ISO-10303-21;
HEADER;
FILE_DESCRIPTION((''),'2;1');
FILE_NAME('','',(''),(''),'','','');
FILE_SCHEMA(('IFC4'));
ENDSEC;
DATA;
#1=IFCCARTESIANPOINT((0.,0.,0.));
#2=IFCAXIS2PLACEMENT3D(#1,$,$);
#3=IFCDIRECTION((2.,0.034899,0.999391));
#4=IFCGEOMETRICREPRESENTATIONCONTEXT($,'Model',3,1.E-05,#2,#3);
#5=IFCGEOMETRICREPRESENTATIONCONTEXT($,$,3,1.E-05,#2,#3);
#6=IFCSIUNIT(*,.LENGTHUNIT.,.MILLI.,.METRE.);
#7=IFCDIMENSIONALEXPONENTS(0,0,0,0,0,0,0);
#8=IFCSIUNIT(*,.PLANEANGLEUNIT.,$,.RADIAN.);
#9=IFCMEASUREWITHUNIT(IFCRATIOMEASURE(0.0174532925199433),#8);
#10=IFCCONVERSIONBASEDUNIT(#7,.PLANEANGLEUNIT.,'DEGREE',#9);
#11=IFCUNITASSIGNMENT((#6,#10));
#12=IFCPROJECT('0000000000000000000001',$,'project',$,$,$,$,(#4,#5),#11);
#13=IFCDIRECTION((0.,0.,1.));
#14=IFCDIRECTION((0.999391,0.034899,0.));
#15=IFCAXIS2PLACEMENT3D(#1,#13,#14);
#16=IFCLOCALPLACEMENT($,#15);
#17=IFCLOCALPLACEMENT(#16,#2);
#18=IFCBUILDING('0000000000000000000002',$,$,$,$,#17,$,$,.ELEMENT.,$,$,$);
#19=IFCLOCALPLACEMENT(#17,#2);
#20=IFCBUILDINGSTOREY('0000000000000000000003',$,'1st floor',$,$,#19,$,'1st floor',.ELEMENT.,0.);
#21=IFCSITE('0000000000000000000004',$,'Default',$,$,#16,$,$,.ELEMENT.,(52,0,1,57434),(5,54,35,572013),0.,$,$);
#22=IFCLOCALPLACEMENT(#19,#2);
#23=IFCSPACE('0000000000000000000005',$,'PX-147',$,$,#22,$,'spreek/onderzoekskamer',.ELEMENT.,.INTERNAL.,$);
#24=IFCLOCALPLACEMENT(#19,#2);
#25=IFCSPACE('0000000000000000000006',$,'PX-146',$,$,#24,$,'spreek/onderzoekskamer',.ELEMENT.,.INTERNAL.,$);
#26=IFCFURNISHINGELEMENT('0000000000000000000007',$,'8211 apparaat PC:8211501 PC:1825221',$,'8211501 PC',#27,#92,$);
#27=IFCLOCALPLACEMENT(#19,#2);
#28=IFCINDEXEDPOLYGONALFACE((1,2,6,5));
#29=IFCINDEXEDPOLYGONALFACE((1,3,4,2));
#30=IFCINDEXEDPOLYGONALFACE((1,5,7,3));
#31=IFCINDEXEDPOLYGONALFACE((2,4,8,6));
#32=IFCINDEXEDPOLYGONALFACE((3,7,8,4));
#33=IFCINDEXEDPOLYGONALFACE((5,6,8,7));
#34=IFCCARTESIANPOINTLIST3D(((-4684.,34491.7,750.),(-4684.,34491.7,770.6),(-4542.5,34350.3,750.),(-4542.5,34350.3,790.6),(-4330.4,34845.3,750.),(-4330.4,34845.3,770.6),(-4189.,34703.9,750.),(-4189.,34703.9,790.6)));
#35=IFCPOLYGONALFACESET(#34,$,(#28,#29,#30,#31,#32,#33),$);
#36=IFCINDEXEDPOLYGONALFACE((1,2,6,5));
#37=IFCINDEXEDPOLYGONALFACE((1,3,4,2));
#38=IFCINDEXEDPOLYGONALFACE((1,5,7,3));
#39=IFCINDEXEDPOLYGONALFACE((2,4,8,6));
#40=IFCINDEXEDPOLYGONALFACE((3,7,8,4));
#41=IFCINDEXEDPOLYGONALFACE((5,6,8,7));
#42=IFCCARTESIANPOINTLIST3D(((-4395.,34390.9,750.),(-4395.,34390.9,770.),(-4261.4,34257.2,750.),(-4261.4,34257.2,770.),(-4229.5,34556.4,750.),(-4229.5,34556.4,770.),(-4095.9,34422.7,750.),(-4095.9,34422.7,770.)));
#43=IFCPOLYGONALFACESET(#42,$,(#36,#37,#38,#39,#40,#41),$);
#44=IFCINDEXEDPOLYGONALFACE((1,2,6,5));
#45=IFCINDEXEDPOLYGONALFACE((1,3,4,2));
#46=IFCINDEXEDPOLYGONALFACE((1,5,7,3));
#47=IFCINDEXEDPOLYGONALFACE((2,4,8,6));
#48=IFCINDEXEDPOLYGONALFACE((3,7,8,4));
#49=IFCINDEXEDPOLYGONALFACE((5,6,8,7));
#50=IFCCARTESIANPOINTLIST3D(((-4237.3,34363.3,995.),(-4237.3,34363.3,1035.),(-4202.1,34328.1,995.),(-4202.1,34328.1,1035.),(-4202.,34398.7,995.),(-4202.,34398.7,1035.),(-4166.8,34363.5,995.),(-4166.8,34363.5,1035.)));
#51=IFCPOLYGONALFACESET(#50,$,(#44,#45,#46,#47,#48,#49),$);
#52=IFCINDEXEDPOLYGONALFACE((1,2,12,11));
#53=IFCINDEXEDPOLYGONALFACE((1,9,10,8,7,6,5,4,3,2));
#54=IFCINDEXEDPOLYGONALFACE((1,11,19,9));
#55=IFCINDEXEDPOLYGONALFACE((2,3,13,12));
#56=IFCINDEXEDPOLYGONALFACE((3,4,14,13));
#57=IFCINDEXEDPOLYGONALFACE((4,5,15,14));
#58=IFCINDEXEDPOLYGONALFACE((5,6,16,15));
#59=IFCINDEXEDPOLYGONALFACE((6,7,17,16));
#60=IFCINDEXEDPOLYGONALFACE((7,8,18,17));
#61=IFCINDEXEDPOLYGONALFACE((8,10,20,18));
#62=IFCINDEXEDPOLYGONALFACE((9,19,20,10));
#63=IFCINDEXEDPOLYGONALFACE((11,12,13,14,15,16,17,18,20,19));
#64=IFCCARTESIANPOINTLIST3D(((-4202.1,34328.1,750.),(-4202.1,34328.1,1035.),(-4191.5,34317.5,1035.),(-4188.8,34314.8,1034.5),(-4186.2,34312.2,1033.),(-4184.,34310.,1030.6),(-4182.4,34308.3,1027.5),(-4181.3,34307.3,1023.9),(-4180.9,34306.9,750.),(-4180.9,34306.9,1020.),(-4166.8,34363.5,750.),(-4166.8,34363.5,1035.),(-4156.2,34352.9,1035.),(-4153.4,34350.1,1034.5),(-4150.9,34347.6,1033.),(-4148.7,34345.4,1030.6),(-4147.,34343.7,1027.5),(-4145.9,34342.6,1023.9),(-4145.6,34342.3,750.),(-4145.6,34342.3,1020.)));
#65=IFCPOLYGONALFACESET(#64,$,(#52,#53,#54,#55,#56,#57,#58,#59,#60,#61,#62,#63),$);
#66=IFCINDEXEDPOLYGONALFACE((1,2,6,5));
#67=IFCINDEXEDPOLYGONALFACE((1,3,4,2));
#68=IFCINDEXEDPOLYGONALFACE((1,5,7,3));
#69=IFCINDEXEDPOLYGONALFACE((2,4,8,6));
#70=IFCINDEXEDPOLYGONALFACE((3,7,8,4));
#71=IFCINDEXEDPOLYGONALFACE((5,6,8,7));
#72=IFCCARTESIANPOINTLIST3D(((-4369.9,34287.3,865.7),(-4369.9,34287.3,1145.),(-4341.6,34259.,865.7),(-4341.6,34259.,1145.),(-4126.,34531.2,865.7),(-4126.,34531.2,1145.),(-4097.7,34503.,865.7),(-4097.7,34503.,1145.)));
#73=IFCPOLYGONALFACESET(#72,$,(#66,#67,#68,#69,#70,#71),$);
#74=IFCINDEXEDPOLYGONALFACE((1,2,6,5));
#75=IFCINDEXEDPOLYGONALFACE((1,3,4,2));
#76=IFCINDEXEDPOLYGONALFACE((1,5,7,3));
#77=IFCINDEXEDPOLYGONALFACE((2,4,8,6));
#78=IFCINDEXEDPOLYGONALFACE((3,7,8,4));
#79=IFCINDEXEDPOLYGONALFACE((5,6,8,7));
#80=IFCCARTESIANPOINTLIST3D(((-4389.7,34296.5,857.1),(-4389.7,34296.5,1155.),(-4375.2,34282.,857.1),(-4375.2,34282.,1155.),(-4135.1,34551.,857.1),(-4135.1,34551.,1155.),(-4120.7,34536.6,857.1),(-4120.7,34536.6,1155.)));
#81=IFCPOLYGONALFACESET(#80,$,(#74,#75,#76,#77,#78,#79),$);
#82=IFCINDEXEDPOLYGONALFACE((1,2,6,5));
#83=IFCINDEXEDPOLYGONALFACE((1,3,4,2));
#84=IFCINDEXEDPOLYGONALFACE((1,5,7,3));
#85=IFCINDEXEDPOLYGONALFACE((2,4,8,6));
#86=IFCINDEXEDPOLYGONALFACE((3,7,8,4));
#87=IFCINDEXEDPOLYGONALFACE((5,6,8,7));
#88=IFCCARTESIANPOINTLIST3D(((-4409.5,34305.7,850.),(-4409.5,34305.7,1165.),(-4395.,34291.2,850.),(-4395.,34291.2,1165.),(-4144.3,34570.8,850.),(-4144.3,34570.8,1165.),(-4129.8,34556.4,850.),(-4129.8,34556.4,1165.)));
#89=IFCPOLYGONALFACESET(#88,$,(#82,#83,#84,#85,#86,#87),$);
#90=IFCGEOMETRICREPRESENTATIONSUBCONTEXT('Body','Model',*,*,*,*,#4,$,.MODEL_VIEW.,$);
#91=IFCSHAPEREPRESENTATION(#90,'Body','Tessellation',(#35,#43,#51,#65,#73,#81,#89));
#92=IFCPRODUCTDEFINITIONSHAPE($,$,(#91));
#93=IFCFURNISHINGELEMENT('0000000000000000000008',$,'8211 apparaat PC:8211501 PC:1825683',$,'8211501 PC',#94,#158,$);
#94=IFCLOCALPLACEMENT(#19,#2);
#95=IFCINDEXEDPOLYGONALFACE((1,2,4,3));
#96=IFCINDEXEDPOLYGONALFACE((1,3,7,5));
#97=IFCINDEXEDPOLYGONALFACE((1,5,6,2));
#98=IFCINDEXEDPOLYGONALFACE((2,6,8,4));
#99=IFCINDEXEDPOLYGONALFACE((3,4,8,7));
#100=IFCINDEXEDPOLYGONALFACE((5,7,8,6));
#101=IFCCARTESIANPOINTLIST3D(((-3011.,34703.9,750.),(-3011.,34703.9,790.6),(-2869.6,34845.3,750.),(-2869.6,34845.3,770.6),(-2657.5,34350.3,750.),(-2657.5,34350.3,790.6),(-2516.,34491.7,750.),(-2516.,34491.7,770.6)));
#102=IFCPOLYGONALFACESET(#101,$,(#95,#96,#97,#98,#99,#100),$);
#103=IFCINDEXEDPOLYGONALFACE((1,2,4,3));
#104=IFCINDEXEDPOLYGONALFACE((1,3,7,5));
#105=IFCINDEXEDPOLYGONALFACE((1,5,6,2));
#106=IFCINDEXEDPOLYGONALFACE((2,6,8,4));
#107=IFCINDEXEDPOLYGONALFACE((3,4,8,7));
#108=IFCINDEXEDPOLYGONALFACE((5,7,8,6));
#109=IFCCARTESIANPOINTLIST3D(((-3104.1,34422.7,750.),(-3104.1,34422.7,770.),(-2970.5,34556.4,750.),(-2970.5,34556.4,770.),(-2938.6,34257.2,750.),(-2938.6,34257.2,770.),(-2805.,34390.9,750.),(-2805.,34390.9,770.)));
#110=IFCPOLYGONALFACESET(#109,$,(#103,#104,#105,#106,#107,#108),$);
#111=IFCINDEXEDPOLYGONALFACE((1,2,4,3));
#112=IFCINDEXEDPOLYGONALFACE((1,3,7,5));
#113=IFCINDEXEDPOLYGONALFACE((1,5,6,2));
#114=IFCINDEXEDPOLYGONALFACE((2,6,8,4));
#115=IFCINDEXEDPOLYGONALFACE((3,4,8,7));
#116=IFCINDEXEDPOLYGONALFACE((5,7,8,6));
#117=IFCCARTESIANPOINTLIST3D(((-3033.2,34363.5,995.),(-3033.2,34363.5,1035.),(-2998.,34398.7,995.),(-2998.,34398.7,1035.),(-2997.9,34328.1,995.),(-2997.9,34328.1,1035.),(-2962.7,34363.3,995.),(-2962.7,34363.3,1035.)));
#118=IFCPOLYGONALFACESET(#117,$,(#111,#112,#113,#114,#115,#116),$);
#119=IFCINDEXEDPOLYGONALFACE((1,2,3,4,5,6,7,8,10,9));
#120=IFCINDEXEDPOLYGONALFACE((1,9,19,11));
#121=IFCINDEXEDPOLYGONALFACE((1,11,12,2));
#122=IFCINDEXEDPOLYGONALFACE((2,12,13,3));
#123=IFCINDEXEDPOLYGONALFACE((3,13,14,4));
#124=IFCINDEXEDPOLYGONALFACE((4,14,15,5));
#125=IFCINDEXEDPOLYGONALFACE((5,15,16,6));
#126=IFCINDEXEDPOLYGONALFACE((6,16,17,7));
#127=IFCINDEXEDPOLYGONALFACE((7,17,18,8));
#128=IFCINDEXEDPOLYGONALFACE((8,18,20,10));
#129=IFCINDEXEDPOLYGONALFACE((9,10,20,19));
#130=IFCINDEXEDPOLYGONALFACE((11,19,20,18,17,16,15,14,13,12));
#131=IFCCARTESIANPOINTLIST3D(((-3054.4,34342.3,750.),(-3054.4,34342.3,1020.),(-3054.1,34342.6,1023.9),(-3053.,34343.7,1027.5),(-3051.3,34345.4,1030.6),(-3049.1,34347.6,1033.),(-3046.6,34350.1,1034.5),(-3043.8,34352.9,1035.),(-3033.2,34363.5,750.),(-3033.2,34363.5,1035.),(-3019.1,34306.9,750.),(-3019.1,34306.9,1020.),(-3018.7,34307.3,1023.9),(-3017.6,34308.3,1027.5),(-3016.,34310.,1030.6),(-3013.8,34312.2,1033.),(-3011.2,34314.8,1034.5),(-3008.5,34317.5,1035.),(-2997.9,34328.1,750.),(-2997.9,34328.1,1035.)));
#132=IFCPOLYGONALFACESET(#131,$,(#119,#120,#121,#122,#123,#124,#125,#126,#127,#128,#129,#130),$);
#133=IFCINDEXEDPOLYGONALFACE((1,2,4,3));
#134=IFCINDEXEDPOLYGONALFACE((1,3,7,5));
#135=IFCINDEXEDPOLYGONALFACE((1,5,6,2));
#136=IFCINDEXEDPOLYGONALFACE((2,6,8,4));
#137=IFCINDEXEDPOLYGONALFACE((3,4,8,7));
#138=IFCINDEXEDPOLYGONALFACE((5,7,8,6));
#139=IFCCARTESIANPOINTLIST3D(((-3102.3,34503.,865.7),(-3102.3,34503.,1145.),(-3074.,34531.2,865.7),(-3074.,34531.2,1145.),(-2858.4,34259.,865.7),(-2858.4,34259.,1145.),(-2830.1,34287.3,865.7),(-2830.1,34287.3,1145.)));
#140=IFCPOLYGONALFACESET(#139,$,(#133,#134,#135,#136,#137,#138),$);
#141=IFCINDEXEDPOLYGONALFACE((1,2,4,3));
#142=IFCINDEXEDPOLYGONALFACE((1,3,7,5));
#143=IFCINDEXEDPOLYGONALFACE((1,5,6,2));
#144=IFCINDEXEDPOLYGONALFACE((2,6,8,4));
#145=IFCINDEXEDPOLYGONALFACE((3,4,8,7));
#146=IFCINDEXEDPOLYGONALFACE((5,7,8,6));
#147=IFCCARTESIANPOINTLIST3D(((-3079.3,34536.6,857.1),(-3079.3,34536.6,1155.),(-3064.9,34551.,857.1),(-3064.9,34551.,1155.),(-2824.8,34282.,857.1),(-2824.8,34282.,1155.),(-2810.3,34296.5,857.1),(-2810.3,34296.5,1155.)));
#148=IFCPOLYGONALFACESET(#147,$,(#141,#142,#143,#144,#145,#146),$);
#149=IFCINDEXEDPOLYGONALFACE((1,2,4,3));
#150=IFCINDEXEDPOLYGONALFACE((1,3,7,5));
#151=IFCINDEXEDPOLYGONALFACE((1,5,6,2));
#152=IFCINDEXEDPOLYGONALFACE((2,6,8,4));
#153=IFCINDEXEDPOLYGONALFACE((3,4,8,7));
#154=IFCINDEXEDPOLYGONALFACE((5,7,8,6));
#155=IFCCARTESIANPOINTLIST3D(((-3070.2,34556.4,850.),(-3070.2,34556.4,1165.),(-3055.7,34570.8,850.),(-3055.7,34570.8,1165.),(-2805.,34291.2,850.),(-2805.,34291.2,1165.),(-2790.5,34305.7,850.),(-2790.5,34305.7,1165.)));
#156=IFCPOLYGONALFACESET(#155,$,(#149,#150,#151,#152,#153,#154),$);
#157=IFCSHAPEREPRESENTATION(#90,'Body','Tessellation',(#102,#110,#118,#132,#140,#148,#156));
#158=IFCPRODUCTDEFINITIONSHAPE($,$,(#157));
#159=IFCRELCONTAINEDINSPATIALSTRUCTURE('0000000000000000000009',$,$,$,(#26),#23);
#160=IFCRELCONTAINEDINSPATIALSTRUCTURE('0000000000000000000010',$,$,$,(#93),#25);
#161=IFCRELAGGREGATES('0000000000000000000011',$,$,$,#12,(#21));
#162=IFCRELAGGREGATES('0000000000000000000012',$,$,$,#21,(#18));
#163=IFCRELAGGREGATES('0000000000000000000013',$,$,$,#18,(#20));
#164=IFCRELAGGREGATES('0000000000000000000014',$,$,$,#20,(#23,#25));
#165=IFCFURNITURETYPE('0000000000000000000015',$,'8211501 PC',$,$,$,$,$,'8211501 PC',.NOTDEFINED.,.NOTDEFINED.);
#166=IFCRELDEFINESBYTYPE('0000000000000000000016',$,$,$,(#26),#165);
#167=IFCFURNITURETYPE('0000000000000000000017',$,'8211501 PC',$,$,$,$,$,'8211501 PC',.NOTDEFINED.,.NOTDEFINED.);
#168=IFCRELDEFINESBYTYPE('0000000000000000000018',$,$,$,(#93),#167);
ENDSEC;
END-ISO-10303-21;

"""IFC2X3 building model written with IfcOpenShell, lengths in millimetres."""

from ifc_helpers import new_model, entity, si_unit, converted_unit, direction, frame, frame_2d, origin, origin_2d_with_axis, place, context, subcontext, project, spatial, polyline, circle_curve, parameter, trimmed, segment, composite_curve, rectangle, outline, extrude, source, transform, mapped, type_object, type_shapes, element, save


model = new_model("IFC2X3")

# Units and contexts
model_context = context("Model", 3, precision=1e-05, world=origin(), true_north=direction((2.0, 0.034899, 0.999391)))
context_of_model = context(None, 3, precision=1e-05, world=origin(), true_north=direction((2.0, 0.034899, 0.999391)))
body_context = subcontext(model_context, "Body", "Model", "MODEL_VIEW")
ifc_project = project(units=[si_unit("LENGTHUNIT", "METRE", prefix="MILLI"), converted_unit("PLANEANGLEUNIT", "DEGREE", entity("IfcRatioMeasure", 0.0174532925199433), si_unit("PLANEANGLEUNIT", "RADIAN"), dimensions=[0, 0, 0, 0, 0, 0, 0])], contexts=[model_context, context_of_model])

# Site, building, storey
site_placement = place(None, frame((0.0, 0.0, 0.0), z_axis=(0.0, 0.0, 1.0), x_axis=(0.999391, 0.034899, 0.0)))
site = spatial("IfcSite", under=ifc_project, at=site_placement, Name="Default", CompositionType="ELEMENT", RefLatitude=(52, 0, 1, 57434), RefLongitude=(5, 54, 35, 572013), RefElevation=0.0)
building_placement = place(site_placement, origin())
building = spatial("IfcBuilding", under=site, at=building_placement, CompositionType="ELEMENT")
storey_placement = place(building_placement, origin())
storey = spatial("IfcBuildingStorey", under=building, at=storey_placement, Name="1st floor", LongName="1st floor", CompositionType="ELEMENT", Elevation=0.0)

# Shared definitions
space_1_placement = place(storey_placement, origin())
space_1 = spatial("IfcSpace", under=storey, at=space_1_placement, Name="PX-147", LongName="spreek/onderzoekskamer", CompositionType="ELEMENT", InteriorOrExteriorSpace="INTERNAL")

# Furnishing element
furniture_type_1 = type_object("IfcFurnitureType", Name="8211501 PC", ElementType="8211501 PC", AssemblyPlace="NOTDEFINED")
shared_shape_1 = source(origin(), body_context, "Body", "SweptSolid", [
    extrude(outline(polyline([(-5.3, -100.0), (15.3, -100.0), (15.3, 100.0), (-25.3, 100.0), (-5.3, -100.0)])), frame((-205.3, -510.0, 765.3), z_axis=(1.0, 0.0, 0.0), x_axis=(0.0, 0.0, -1.0)), (0.0, 0.0, 1.0), 500.0),
    extrude(rectangle(XDim=189.0, YDim=234.0, at=origin_2d_with_axis()), frame((44.7, -239.9, 750.0), z_axis=(0.0, 0.0, 1.0), x_axis=(0.0, 1.0, 0.0)), (0.0, 0.0, 1.0), 20.0),
    extrude(rectangle(XDim=49.8, YDim=50.0, at=frame_2d((0.0, 0.0), x_axis=(1.0, 0.0))), frame((44.7, -178.5, 995.0), z_axis=(0.0, 0.0, 1.0), x_axis=(0.0, 1.0, 0.0)), (0.0, 0.0, 1.0), 40.0),
    extrude(outline(composite_curve([segment(polyline([(-117.0, -15.0), (168.0, -15.0)]), True, "CONTINUOUS"), segment(polyline([(168.0, -15.0), (168.0, 15.0)]), True, "CONTINUOUS"), segment(polyline([(168.0, 15.0), (-102.0, 15.0)]), True, "CONTINUOUS"), segment(trimmed(circle_curve(frame_2d((-102.0, 0.0), x_axis=(0.0, 1.0)), 15.0), [parameter(360.0)], [parameter(90.0)], True, "PARAMETER"), True, "CONTINUOUS"), segment(polyline([(-117.0, 0.0), (-117.0, -15.0)]), True, "CONTINUOUS")], self_intersect=False)), frame((19.7, -138.6, 918.0), z_axis=(1.0, 0.0, 0.0), x_axis=(0.0, 0.0, -1.0)), (0.0, 0.0, 1.0), 50.0),
    extrude(rectangle(XDim=40.0, YDim=345.0, at=origin_2d_with_axis()), frame((44.7, -223.4, 865.7), z_axis=(0.0, 0.0, 1.0), x_axis=(0.0, 1.0, 0.0)), (0.0, 0.0, 1.0), 279.3),
    extrude(rectangle(XDim=20.5, YDim=360.0, at=origin_2d_with_axis()), frame((44.7, -253.6, 857.1), z_axis=(0.0, 0.0, 1.0), x_axis=(0.0, 1.0, 0.0)), (0.0, 0.0, 1.0), 297.9),
    extrude(rectangle(XDim=20.5, YDim=375.0, at=origin_2d_with_axis()), frame((44.7, -274.1, 850.0), z_axis=(0.0, 0.0, 1.0), x_axis=(0.0, 1.0, 0.0)), (0.0, 0.0, 1.0), 315.0),
])
type_shapes(furniture_type_1, [shared_shape_1])
furnishing_1_placement = place(space_1_placement, frame((-4044.2, 34268.8, 0.0), z_axis=(0.0, 0.0, 1.0), x_axis=(-0.707107, -0.707107, 0.0)))
element("IfcFurnishingElement", 1, at=furnishing_1_placement, inside=space_1, type_object=furniture_type_1, Name="8211 apparaat PC:8211501 PC:1825221", ObjectType="8211501 PC", context=body_context, shape_type="MappedRepresentation", body=[
    mapped(shared_shape_1, transform((0.0, 0.0, 0.0), scale=1.0)),
])

# Shared definitions
space_2_placement = place(storey_placement, origin())
space_2 = spatial("IfcSpace", under=storey, at=space_2_placement, Name="PX-146", LongName="spreek/onderzoekskamer", CompositionType="ELEMENT", InteriorOrExteriorSpace="INTERNAL")

# Furnishing element
furniture_type_2 = type_object("IfcFurnitureType", Name="8211501 PC", ElementType="8211501 PC", AssemblyPlace="NOTDEFINED")
shared_shape_2 = source(origin(), body_context, "Body", "SweptSolid", [
    extrude(outline(polyline([(-99.0, -15.2), (102.0, -15.2), (98.0, 25.2), (-101.0, 5.3), (-99.0, -15.2)])), frame((-205.3, 510.0, 765.3), z_axis=(1.0, 0.0, 0.0), x_axis=(0.0, -0.995037, 0.099504)), (0.0, 0.0, 1.0), 500.0),
    extrude(rectangle(XDim=234.0, YDim=189.0, at=frame_2d((0.0, 0.0), x_axis=(1.0, 0.0))), frame((44.7, 239.9, 750.0), z_axis=(0.0, 0.0, 1.0), x_axis=(-1.0, 0.0, 0.0)), (0.0, 0.0, 1.0), 20.0),
    extrude(rectangle(XDim=50.0, YDim=49.8, at=frame_2d((0.0, 0.0), x_axis=(1.0, 0.0))), frame((44.7, 178.5, 995.0), z_axis=(0.0, 0.0, 1.0), x_axis=(-1.0, 0.0, 0.0)), (0.0, 0.0, 1.0), 40.0),
    extrude(outline(composite_curve([segment(polyline([(-15.0, -117.0), (0.0, -117.0)]), True, "CONTINUOUS"), segment(trimmed(circle_curve(frame_2d((0.0, -102.0), x_axis=(1.0, 0.0)), 15.0), [parameter(270.0)], [parameter(0.0)], True, "PARAMETER"), True, "CONTINUOUS"), segment(polyline([(15.0, -102.0), (15.0, 168.0)]), True, "CONTINUOUS"), segment(polyline([(15.0, 168.0), (-15.0, 168.0)]), True, "CONTINUOUS"), segment(polyline([(-15.0, 168.0), (-15.0, -117.0)]), True, "CONTINUOUS")], self_intersect=False)), frame((19.7, 138.6, 918.0), z_axis=(1.0, 0.0, 0.0), x_axis=(0.0, -1.0, 0.0)), (0.0, 0.0, 1.0), 50.0),
    extrude(rectangle(XDim=345.0, YDim=40.0, at=origin_2d_with_axis()), frame((44.7, 223.4, 865.7), z_axis=(0.0, 0.0, 1.0), x_axis=(-1.0, 0.0, 0.0)), (0.0, 0.0, 1.0), 279.3),
    extrude(rectangle(XDim=360.0, YDim=20.5, at=origin_2d_with_axis()), frame((44.7, 253.6, 857.1), z_axis=(0.0, 0.0, 1.0), x_axis=(-1.0, 0.0, 0.0)), (0.0, 0.0, 1.0), 297.9),
    extrude(rectangle(XDim=375.0, YDim=20.5, at=origin_2d_with_axis()), frame((44.7, 274.1, 850.0), z_axis=(0.0, 0.0, 1.0), x_axis=(-1.0, 0.0, 0.0)), (0.0, 0.0, 1.0), 315.0),
])
type_shapes(furniture_type_2, [shared_shape_2])
furnishing_2_placement = place(space_2_placement, frame((-3155.8, 34268.8, 0.0), z_axis=(0.0, 0.0, 1.0), x_axis=(0.707107, -0.707107, 0.0)))
element("IfcFurnishingElement", 2, at=furnishing_2_placement, inside=space_2, type_object=furniture_type_2, Name="8211 apparaat PC:8211501 PC:1825683", ObjectType="8211501 PC", context=body_context, shape_type="MappedRepresentation", body=[
    mapped(shared_shape_2, transform((0.0, 0.0, 0.0), scale=1.0)),
])

save(model, "model.ifc")
